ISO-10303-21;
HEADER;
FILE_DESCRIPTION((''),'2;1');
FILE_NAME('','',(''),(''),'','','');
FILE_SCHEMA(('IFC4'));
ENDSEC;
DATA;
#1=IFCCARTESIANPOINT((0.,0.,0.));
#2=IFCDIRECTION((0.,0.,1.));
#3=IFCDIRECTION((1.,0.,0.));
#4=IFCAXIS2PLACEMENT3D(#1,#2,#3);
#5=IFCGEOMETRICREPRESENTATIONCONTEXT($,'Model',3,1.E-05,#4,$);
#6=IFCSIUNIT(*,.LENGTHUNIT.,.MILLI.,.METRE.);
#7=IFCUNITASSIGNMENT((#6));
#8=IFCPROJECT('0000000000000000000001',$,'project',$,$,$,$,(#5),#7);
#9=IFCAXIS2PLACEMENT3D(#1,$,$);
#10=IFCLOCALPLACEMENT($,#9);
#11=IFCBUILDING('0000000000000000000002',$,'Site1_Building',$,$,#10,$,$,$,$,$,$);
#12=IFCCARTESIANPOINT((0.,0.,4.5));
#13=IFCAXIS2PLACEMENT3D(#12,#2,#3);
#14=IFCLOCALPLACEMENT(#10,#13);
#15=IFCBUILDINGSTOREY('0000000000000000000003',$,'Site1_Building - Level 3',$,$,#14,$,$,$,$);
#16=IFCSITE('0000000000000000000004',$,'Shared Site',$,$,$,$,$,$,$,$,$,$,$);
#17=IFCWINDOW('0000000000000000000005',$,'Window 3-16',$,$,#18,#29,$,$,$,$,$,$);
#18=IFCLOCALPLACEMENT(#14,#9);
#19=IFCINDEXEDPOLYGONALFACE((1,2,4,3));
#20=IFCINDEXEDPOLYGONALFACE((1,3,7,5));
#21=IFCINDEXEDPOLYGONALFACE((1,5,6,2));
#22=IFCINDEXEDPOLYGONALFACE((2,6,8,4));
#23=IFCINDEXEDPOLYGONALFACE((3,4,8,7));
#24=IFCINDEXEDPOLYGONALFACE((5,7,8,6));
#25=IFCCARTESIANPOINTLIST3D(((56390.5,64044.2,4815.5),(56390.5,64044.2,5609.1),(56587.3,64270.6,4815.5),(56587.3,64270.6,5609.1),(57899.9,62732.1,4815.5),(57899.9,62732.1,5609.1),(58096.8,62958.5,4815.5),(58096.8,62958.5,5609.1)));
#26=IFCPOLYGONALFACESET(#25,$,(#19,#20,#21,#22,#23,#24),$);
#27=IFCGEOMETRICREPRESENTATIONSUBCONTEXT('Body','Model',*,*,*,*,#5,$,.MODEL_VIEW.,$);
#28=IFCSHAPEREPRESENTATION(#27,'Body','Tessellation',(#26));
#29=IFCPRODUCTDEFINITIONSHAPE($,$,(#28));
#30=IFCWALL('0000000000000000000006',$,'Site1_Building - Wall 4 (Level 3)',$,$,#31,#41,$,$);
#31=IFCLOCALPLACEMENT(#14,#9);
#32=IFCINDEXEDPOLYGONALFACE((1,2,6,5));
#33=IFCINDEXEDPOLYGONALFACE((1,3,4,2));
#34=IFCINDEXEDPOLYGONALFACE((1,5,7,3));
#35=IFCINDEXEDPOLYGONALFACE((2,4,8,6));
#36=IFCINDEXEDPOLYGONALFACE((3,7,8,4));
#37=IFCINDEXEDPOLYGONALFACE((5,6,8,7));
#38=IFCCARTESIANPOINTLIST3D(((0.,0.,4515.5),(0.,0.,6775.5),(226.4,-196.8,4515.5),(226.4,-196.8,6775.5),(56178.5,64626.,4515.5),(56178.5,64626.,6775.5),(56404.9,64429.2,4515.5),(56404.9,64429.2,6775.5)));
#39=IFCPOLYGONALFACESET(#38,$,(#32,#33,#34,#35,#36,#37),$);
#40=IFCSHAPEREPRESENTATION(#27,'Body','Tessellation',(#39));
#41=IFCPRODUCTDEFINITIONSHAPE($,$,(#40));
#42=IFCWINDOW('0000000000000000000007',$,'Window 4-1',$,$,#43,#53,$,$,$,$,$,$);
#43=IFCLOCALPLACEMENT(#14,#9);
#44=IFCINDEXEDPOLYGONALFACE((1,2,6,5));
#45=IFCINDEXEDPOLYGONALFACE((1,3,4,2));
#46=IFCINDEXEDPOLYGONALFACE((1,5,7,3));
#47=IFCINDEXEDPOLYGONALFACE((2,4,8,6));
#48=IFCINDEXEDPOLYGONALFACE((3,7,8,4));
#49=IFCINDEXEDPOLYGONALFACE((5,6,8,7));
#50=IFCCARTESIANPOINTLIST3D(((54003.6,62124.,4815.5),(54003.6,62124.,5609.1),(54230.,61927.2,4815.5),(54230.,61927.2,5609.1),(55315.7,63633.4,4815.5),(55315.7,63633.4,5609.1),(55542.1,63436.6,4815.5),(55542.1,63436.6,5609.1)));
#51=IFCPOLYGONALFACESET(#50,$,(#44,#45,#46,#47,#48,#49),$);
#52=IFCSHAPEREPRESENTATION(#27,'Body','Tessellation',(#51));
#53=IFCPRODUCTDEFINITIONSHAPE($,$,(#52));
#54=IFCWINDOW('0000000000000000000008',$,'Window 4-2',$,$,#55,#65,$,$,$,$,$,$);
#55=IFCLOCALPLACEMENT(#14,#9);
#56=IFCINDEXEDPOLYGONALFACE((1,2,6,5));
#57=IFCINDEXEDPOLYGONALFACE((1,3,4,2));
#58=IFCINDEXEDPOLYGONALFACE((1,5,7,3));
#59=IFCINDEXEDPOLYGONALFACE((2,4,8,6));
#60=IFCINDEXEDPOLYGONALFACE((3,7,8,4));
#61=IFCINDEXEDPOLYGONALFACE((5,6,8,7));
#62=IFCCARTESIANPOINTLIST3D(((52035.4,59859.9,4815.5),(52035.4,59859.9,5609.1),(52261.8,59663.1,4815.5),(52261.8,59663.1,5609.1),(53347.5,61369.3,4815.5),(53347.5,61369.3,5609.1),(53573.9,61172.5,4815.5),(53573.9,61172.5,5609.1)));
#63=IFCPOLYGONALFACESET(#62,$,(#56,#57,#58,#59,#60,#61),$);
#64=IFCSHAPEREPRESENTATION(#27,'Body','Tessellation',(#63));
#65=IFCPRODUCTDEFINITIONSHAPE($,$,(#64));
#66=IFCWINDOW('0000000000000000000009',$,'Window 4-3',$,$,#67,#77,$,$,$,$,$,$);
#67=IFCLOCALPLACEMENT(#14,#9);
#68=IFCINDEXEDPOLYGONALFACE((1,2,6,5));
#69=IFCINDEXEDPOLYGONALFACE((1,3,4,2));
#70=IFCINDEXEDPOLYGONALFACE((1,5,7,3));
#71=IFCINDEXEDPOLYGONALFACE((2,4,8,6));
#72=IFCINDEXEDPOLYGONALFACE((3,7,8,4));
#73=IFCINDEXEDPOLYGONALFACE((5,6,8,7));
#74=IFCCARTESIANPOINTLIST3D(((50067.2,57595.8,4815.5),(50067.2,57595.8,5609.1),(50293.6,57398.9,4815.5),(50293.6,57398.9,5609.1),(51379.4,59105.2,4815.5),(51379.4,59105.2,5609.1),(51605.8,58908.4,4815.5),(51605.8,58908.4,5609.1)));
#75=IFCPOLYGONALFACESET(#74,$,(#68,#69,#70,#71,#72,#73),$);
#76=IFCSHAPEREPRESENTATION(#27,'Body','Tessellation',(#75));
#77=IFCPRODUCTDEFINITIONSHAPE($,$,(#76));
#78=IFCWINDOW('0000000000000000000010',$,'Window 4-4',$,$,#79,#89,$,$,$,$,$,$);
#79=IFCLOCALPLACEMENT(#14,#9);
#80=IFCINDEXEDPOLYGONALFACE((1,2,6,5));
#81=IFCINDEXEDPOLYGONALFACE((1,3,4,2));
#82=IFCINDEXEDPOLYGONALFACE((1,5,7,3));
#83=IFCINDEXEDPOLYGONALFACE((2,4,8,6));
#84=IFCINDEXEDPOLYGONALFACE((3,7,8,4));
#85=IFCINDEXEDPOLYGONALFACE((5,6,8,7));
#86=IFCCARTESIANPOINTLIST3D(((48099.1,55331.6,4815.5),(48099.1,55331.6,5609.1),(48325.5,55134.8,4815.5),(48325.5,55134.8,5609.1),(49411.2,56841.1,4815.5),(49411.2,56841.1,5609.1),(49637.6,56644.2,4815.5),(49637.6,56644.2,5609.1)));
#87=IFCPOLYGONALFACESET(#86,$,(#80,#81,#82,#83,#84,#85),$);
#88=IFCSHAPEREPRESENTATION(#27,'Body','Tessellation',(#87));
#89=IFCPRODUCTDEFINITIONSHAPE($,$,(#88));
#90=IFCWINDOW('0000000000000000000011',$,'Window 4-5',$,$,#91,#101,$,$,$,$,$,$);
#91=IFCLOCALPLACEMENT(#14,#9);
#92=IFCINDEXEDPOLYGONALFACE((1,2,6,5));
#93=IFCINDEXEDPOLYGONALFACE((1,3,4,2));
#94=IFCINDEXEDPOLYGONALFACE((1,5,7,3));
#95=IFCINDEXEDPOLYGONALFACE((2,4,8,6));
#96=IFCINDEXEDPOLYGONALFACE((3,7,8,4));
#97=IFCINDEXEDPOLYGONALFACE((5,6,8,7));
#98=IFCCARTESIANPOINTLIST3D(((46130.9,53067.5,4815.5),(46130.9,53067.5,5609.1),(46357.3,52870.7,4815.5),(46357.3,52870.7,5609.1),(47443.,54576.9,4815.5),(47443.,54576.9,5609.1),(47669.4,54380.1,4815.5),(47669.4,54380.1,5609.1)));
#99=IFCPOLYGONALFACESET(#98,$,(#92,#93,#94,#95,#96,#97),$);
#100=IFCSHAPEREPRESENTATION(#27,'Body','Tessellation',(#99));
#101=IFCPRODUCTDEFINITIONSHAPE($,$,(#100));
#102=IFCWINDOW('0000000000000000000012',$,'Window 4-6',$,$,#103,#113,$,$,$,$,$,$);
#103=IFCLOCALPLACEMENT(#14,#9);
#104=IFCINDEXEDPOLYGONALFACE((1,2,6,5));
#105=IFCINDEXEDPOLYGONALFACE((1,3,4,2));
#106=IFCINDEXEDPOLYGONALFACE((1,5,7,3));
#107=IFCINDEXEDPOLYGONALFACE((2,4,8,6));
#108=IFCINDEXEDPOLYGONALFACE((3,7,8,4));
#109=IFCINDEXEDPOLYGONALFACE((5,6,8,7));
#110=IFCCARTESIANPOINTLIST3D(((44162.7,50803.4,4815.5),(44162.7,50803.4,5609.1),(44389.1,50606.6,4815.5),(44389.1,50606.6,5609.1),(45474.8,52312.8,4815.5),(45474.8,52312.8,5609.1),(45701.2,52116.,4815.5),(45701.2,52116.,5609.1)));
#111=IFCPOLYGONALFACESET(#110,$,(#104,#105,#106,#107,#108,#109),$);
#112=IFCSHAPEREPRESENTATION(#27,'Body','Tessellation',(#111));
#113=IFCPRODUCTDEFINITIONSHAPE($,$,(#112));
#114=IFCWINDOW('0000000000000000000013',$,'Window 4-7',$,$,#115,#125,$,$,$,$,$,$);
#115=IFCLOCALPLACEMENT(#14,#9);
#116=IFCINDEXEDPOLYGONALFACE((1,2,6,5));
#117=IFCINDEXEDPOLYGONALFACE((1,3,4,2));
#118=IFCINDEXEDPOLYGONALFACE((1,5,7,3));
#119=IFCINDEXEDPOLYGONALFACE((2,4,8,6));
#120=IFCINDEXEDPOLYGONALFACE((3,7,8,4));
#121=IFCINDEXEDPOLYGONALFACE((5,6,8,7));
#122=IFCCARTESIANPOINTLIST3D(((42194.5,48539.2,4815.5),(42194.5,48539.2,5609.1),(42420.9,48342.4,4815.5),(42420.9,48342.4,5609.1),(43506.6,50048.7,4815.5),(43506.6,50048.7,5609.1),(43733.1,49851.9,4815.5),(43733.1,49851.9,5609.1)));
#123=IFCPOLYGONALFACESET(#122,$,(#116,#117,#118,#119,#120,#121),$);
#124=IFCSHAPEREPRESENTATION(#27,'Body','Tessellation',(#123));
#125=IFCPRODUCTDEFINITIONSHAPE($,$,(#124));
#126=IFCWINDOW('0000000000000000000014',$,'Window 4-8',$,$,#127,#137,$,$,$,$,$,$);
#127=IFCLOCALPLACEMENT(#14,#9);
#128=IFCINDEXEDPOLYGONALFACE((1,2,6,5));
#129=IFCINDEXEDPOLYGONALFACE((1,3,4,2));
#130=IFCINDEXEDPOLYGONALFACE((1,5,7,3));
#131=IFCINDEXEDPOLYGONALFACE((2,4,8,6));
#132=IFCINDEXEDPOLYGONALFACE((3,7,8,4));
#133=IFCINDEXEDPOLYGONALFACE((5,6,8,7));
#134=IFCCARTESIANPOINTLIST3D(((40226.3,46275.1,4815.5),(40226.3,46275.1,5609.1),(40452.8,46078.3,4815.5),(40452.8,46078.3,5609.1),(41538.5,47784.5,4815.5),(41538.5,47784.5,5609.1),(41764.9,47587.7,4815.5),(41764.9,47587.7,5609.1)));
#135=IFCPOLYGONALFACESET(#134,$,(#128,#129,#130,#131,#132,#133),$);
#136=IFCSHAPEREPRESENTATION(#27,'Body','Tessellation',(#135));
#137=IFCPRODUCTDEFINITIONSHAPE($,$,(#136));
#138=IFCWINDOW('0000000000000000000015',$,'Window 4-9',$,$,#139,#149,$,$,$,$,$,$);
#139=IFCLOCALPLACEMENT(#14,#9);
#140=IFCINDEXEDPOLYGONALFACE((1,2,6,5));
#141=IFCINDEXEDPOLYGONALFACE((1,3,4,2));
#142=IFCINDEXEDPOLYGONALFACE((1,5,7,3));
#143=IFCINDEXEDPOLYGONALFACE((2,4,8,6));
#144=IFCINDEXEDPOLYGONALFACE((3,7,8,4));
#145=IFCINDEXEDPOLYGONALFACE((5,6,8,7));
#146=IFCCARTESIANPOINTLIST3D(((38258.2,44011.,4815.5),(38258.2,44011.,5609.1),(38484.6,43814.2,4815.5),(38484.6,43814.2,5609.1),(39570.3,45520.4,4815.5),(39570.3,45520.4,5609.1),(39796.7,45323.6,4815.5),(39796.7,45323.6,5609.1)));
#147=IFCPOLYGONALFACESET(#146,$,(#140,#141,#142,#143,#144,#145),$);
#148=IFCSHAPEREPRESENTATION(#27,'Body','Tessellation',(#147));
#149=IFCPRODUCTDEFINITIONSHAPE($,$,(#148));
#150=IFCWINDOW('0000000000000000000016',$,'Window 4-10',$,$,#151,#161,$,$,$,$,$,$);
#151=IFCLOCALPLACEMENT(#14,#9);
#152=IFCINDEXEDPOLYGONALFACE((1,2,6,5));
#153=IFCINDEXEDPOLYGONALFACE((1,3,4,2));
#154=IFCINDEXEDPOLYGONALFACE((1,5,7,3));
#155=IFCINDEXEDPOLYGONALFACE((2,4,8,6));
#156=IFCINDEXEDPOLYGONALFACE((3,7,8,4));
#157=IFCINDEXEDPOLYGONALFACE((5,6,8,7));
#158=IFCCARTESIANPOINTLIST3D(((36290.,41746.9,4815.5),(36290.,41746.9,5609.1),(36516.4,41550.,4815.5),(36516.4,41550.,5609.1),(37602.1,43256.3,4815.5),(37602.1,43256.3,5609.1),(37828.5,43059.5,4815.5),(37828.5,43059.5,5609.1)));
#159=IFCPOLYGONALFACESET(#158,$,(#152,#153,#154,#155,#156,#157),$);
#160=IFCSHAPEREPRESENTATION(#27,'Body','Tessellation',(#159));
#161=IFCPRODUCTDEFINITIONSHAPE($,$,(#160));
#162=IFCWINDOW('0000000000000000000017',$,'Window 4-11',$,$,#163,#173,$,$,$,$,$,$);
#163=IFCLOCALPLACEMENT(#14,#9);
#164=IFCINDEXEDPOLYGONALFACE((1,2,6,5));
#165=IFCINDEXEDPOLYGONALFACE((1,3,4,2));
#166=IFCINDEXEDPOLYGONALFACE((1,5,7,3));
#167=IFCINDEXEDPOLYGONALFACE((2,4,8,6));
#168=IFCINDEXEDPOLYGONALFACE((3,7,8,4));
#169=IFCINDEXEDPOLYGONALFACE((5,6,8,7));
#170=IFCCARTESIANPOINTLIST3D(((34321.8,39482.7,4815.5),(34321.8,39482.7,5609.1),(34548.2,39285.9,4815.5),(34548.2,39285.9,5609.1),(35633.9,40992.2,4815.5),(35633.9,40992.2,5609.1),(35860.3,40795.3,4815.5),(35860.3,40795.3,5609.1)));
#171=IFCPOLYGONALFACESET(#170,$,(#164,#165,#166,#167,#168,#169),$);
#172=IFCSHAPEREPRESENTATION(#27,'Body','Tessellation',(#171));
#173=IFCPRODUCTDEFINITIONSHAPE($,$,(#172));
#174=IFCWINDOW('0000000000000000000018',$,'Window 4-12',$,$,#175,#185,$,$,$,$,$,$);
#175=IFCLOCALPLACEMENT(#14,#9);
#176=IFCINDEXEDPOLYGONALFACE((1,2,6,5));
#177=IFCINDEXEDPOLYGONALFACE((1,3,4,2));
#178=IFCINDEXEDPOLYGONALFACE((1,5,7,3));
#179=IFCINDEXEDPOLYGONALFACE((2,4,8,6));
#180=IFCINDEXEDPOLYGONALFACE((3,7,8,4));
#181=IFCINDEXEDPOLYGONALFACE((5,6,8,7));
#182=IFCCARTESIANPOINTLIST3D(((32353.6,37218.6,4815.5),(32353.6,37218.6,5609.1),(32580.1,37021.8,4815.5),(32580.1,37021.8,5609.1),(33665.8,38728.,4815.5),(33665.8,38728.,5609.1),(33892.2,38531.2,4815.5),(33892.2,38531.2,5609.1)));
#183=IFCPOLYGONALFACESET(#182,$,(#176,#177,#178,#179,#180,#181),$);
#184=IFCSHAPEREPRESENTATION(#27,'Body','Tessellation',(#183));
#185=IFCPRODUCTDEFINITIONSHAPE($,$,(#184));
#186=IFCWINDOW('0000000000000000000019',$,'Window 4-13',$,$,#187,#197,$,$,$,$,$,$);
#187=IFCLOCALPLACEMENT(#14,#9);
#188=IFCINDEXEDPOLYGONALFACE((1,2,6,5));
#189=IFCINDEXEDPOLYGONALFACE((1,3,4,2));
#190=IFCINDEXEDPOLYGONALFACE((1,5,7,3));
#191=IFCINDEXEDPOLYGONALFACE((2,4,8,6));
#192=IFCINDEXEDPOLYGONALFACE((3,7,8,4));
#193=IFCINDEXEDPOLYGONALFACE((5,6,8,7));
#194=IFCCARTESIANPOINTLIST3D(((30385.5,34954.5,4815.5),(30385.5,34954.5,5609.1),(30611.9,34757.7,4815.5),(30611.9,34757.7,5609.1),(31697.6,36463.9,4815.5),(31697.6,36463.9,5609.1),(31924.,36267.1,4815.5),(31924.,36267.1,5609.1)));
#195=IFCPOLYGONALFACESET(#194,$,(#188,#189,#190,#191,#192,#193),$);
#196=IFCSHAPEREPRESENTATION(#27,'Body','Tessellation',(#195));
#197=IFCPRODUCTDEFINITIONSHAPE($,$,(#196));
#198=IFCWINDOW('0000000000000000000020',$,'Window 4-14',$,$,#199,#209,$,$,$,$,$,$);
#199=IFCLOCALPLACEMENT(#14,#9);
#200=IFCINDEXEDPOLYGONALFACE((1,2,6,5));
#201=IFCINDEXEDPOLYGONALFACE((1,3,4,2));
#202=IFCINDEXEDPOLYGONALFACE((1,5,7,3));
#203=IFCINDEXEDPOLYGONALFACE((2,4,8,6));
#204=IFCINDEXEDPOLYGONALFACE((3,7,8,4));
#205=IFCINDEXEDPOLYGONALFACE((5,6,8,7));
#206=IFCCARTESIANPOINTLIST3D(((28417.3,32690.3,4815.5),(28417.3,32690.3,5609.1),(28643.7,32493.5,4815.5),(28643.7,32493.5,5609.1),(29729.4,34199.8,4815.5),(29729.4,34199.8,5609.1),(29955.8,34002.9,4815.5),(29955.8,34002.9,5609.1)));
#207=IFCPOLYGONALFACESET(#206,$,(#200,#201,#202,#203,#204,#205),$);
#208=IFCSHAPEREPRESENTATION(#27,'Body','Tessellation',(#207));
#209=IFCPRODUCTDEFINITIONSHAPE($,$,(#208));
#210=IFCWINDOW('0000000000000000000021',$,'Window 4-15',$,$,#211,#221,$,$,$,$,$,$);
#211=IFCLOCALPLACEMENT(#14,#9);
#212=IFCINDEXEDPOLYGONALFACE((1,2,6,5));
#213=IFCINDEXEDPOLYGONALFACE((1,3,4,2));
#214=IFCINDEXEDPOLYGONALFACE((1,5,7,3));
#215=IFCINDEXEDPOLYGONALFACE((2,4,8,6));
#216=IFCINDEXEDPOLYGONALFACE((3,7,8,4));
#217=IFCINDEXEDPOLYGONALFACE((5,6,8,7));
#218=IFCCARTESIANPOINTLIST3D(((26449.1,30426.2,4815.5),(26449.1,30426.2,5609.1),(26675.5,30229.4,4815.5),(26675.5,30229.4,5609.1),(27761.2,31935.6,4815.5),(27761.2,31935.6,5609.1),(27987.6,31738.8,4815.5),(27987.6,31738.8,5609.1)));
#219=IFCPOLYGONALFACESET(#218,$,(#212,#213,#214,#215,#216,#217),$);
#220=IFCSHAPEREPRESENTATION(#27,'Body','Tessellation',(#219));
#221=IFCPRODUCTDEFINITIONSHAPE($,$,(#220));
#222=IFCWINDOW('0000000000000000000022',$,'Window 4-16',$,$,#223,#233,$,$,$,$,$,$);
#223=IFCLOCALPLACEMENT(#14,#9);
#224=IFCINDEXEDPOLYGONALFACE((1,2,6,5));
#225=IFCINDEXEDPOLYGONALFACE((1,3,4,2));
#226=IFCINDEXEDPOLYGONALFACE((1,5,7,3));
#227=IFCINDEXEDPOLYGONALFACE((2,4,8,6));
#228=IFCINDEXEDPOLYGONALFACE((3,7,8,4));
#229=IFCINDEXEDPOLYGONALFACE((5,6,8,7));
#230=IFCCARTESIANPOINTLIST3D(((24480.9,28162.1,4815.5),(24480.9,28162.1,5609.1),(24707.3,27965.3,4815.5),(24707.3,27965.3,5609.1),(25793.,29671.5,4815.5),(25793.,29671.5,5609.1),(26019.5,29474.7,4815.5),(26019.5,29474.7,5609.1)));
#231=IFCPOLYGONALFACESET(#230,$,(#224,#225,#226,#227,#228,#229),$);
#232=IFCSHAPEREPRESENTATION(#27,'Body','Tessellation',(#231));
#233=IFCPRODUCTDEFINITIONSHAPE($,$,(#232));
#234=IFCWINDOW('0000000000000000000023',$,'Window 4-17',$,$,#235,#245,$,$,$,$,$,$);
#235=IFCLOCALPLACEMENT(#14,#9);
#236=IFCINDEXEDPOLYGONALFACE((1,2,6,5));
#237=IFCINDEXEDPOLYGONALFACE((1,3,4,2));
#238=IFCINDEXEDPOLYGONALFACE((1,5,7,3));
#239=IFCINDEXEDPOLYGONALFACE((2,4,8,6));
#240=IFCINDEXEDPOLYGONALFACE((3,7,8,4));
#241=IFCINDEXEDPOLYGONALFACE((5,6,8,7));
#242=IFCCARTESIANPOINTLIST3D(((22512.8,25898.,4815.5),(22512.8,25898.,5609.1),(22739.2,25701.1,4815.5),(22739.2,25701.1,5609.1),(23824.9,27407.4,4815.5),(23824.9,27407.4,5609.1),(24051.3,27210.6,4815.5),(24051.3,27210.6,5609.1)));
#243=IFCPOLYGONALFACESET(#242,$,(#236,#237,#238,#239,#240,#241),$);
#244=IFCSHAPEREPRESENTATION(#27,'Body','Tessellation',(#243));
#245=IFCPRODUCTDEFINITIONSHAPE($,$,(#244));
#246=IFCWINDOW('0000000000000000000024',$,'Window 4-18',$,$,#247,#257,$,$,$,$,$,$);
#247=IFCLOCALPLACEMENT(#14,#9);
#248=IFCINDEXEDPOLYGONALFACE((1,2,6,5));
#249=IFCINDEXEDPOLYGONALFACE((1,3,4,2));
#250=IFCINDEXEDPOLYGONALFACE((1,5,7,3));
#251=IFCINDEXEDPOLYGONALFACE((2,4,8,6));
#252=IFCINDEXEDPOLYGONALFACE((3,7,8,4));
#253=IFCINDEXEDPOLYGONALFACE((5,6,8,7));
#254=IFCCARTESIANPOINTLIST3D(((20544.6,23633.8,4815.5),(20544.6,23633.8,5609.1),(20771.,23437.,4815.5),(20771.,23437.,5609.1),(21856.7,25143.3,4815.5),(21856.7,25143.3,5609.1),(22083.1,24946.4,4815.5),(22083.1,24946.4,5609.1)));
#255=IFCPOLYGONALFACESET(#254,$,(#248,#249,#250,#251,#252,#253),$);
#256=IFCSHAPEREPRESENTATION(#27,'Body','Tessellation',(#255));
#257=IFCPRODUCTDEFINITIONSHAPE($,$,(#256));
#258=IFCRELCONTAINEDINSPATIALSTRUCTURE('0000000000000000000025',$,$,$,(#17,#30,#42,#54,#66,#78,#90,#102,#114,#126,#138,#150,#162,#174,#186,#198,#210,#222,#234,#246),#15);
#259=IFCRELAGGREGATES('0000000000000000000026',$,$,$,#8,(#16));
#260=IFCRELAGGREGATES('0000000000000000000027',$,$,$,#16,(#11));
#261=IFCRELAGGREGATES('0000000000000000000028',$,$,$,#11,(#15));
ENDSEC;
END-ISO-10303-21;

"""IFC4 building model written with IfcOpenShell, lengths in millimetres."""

from ifc_helpers import new_model, si_unit, frame, origin, origin_with_axes, place, context, subcontext, project, spatial, indexed_curve, outline, extrude, element, save


model = new_model("IFC4")

# Units and contexts
model_context = context("Model", 3, precision=1e-05, world=origin_with_axes())
body_context = subcontext(model_context, "Body", "Model", "MODEL_VIEW")
ifc_project = project(units=[si_unit("LENGTHUNIT", "METRE", prefix="MILLI")], contexts=[model_context])

# Site, building, storey
site = spatial("IfcSite", under=ifc_project, Name="Shared Site")
building_placement = place(None, origin())
building = spatial("IfcBuilding", under=site, at=building_placement, Name="Site1_Building")
storey_placement = place(building_placement, frame((0.0, 0.0, 4.5), z_axis=(0.0, 0.0, 1.0), x_axis=(1.0, 0.0, 0.0)))
storey = spatial("IfcBuildingStorey", under=building, at=storey_placement, Name="Site1_Building - Level 3")

# Window
window_placement = place(storey_placement, frame((58096.8, 62958.5, 4815.5), z_axis=(0.0, 0.0, 1.0), x_axis=(-0.75471, 0.656059, 0.0)))
element("IfcWindow", 1, at=window_placement, inside=storey, Name="Window 3-16", context=body_context, shape_type="SweptSolid", body=[
    extrude(outline(indexed_curve([(0.0, 0.0), (0.0, 300.0), (2000.0, 300.0), (2000.0, 0.0), (0.0, 0.0)], self_intersect=False)), origin_with_axes(), (0.0, 0.0, 1.0), 793.6),
])

# Wall
wall_placement = place(storey_placement, frame((56178.5, 64626.0, 4515.5), z_axis=(0.0, 0.0, 1.0), x_axis=(-0.656059, -0.75471, 0.0)))
element("IfcWall", 2, at=wall_placement, inside=storey, Name="Site1_Building - Wall 4 (Level 3)", context=body_context, shape_type="SweptSolid", body=[
    extrude(outline(indexed_curve([(0.0, 0.0), (0.0, 300.0), (85630.3, 300.0), (85630.3, 0.0), (0.0, 0.0)], self_intersect=False)), origin_with_axes(), (0.0, 0.0, 1.0), 2260.0),
])

# Windows
for number, where, z_axis, x_axis, name in (
    (3, (55315.7, 63633.4, 4815.5), (0.0, 0.0, 1.0), (-0.656059, -0.75471, 0.0), "Window 4-1"),
    (4, (53347.5, 61369.3, 4815.5), (0.0, 0.0, 1.0), (-0.656059, -0.75471, 0.0), "Window 4-2"),
    (5, (51379.4, 59105.2, 4815.5), (0.0, 0.0, 1.0), (-0.656059, -0.75471, 0.0), "Window 4-3"),
    (6, (49411.2, 56841.1, 4815.5), (0.0, 0.0, 1.0), (-0.656059, -0.75471, 0.0), "Window 4-4"),
    (7, (47443.0, 54576.9, 4815.5), (0.0, 0.0, 1.0), (-0.656059, -0.75471, 0.0), "Window 4-5"),
    (8, (45474.8, 52312.8, 4815.5), (0.0, 0.0, 1.0), (-0.656059, -0.75471, 0.0), "Window 4-6"),
    (9, (43506.6, 50048.7, 4815.5), (0.0, 0.0, 1.0), (-0.656059, -0.75471, 0.0), "Window 4-7"),
    (10, (41538.5, 47784.5, 4815.5), (0.0, 0.0, 1.0), (-0.656059, -0.75471, 0.0), "Window 4-8"),
    (11, (39570.3, 45520.4, 4815.5), (0.0, 0.0, 1.0), (-0.656059, -0.75471, 0.0), "Window 4-9"),
    (12, (37602.1, 43256.3, 4815.5), (0.0, 0.0, 1.0), (-0.656059, -0.75471, 0.0), "Window 4-10"),
    (13, (35633.9, 40992.2, 4815.5), (0.0, 0.0, 1.0), (-0.656059, -0.75471, 0.0), "Window 4-11"),
    (14, (33665.8, 38728.0, 4815.5), (0.0, 0.0, 1.0), (-0.656059, -0.75471, 0.0), "Window 4-12"),
    (15, (31697.6, 36463.9, 4815.5), (0.0, 0.0, 1.0), (-0.656059, -0.75471, 0.0), "Window 4-13"),
    (16, (29729.4, 34199.8, 4815.5), (0.0, 0.0, 1.0), (-0.656059, -0.75471, 0.0), "Window 4-14"),
    (17, (27761.2, 31935.6, 4815.5), (0.0, 0.0, 1.0), (-0.656059, -0.75471, 0.0), "Window 4-15"),
    (18, (25793.0, 29671.5, 4815.5), (0.0, 0.0, 1.0), (-0.656059, -0.75471, 0.0), "Window 4-16"),
    (19, (23824.9, 27407.4, 4815.5), (0.0, 0.0, 1.0), (-0.656059, -0.75471, 0.0), "Window 4-17"),
    (20, (21856.7, 25143.3, 4815.5), (0.0, 0.0, 1.0), (-0.656059, -0.75471, 0.0), "Window 4-18"),
):
    element("IfcWindow", number, at=place(storey_placement, frame(where, z_axis=z_axis, x_axis=x_axis)), inside=storey, Name=name, context=body_context, shape_type="SweptSolid", body=[
        extrude(outline(indexed_curve([(0.0, 0.0), (0.0, 300.0), (2000.0, 300.0), (2000.0, 0.0), (0.0, 0.0)], self_intersect=False)), origin_with_axes(), (0.0, 0.0, 1.0), 793.6),
    ])

save(model, "model.ifc")
